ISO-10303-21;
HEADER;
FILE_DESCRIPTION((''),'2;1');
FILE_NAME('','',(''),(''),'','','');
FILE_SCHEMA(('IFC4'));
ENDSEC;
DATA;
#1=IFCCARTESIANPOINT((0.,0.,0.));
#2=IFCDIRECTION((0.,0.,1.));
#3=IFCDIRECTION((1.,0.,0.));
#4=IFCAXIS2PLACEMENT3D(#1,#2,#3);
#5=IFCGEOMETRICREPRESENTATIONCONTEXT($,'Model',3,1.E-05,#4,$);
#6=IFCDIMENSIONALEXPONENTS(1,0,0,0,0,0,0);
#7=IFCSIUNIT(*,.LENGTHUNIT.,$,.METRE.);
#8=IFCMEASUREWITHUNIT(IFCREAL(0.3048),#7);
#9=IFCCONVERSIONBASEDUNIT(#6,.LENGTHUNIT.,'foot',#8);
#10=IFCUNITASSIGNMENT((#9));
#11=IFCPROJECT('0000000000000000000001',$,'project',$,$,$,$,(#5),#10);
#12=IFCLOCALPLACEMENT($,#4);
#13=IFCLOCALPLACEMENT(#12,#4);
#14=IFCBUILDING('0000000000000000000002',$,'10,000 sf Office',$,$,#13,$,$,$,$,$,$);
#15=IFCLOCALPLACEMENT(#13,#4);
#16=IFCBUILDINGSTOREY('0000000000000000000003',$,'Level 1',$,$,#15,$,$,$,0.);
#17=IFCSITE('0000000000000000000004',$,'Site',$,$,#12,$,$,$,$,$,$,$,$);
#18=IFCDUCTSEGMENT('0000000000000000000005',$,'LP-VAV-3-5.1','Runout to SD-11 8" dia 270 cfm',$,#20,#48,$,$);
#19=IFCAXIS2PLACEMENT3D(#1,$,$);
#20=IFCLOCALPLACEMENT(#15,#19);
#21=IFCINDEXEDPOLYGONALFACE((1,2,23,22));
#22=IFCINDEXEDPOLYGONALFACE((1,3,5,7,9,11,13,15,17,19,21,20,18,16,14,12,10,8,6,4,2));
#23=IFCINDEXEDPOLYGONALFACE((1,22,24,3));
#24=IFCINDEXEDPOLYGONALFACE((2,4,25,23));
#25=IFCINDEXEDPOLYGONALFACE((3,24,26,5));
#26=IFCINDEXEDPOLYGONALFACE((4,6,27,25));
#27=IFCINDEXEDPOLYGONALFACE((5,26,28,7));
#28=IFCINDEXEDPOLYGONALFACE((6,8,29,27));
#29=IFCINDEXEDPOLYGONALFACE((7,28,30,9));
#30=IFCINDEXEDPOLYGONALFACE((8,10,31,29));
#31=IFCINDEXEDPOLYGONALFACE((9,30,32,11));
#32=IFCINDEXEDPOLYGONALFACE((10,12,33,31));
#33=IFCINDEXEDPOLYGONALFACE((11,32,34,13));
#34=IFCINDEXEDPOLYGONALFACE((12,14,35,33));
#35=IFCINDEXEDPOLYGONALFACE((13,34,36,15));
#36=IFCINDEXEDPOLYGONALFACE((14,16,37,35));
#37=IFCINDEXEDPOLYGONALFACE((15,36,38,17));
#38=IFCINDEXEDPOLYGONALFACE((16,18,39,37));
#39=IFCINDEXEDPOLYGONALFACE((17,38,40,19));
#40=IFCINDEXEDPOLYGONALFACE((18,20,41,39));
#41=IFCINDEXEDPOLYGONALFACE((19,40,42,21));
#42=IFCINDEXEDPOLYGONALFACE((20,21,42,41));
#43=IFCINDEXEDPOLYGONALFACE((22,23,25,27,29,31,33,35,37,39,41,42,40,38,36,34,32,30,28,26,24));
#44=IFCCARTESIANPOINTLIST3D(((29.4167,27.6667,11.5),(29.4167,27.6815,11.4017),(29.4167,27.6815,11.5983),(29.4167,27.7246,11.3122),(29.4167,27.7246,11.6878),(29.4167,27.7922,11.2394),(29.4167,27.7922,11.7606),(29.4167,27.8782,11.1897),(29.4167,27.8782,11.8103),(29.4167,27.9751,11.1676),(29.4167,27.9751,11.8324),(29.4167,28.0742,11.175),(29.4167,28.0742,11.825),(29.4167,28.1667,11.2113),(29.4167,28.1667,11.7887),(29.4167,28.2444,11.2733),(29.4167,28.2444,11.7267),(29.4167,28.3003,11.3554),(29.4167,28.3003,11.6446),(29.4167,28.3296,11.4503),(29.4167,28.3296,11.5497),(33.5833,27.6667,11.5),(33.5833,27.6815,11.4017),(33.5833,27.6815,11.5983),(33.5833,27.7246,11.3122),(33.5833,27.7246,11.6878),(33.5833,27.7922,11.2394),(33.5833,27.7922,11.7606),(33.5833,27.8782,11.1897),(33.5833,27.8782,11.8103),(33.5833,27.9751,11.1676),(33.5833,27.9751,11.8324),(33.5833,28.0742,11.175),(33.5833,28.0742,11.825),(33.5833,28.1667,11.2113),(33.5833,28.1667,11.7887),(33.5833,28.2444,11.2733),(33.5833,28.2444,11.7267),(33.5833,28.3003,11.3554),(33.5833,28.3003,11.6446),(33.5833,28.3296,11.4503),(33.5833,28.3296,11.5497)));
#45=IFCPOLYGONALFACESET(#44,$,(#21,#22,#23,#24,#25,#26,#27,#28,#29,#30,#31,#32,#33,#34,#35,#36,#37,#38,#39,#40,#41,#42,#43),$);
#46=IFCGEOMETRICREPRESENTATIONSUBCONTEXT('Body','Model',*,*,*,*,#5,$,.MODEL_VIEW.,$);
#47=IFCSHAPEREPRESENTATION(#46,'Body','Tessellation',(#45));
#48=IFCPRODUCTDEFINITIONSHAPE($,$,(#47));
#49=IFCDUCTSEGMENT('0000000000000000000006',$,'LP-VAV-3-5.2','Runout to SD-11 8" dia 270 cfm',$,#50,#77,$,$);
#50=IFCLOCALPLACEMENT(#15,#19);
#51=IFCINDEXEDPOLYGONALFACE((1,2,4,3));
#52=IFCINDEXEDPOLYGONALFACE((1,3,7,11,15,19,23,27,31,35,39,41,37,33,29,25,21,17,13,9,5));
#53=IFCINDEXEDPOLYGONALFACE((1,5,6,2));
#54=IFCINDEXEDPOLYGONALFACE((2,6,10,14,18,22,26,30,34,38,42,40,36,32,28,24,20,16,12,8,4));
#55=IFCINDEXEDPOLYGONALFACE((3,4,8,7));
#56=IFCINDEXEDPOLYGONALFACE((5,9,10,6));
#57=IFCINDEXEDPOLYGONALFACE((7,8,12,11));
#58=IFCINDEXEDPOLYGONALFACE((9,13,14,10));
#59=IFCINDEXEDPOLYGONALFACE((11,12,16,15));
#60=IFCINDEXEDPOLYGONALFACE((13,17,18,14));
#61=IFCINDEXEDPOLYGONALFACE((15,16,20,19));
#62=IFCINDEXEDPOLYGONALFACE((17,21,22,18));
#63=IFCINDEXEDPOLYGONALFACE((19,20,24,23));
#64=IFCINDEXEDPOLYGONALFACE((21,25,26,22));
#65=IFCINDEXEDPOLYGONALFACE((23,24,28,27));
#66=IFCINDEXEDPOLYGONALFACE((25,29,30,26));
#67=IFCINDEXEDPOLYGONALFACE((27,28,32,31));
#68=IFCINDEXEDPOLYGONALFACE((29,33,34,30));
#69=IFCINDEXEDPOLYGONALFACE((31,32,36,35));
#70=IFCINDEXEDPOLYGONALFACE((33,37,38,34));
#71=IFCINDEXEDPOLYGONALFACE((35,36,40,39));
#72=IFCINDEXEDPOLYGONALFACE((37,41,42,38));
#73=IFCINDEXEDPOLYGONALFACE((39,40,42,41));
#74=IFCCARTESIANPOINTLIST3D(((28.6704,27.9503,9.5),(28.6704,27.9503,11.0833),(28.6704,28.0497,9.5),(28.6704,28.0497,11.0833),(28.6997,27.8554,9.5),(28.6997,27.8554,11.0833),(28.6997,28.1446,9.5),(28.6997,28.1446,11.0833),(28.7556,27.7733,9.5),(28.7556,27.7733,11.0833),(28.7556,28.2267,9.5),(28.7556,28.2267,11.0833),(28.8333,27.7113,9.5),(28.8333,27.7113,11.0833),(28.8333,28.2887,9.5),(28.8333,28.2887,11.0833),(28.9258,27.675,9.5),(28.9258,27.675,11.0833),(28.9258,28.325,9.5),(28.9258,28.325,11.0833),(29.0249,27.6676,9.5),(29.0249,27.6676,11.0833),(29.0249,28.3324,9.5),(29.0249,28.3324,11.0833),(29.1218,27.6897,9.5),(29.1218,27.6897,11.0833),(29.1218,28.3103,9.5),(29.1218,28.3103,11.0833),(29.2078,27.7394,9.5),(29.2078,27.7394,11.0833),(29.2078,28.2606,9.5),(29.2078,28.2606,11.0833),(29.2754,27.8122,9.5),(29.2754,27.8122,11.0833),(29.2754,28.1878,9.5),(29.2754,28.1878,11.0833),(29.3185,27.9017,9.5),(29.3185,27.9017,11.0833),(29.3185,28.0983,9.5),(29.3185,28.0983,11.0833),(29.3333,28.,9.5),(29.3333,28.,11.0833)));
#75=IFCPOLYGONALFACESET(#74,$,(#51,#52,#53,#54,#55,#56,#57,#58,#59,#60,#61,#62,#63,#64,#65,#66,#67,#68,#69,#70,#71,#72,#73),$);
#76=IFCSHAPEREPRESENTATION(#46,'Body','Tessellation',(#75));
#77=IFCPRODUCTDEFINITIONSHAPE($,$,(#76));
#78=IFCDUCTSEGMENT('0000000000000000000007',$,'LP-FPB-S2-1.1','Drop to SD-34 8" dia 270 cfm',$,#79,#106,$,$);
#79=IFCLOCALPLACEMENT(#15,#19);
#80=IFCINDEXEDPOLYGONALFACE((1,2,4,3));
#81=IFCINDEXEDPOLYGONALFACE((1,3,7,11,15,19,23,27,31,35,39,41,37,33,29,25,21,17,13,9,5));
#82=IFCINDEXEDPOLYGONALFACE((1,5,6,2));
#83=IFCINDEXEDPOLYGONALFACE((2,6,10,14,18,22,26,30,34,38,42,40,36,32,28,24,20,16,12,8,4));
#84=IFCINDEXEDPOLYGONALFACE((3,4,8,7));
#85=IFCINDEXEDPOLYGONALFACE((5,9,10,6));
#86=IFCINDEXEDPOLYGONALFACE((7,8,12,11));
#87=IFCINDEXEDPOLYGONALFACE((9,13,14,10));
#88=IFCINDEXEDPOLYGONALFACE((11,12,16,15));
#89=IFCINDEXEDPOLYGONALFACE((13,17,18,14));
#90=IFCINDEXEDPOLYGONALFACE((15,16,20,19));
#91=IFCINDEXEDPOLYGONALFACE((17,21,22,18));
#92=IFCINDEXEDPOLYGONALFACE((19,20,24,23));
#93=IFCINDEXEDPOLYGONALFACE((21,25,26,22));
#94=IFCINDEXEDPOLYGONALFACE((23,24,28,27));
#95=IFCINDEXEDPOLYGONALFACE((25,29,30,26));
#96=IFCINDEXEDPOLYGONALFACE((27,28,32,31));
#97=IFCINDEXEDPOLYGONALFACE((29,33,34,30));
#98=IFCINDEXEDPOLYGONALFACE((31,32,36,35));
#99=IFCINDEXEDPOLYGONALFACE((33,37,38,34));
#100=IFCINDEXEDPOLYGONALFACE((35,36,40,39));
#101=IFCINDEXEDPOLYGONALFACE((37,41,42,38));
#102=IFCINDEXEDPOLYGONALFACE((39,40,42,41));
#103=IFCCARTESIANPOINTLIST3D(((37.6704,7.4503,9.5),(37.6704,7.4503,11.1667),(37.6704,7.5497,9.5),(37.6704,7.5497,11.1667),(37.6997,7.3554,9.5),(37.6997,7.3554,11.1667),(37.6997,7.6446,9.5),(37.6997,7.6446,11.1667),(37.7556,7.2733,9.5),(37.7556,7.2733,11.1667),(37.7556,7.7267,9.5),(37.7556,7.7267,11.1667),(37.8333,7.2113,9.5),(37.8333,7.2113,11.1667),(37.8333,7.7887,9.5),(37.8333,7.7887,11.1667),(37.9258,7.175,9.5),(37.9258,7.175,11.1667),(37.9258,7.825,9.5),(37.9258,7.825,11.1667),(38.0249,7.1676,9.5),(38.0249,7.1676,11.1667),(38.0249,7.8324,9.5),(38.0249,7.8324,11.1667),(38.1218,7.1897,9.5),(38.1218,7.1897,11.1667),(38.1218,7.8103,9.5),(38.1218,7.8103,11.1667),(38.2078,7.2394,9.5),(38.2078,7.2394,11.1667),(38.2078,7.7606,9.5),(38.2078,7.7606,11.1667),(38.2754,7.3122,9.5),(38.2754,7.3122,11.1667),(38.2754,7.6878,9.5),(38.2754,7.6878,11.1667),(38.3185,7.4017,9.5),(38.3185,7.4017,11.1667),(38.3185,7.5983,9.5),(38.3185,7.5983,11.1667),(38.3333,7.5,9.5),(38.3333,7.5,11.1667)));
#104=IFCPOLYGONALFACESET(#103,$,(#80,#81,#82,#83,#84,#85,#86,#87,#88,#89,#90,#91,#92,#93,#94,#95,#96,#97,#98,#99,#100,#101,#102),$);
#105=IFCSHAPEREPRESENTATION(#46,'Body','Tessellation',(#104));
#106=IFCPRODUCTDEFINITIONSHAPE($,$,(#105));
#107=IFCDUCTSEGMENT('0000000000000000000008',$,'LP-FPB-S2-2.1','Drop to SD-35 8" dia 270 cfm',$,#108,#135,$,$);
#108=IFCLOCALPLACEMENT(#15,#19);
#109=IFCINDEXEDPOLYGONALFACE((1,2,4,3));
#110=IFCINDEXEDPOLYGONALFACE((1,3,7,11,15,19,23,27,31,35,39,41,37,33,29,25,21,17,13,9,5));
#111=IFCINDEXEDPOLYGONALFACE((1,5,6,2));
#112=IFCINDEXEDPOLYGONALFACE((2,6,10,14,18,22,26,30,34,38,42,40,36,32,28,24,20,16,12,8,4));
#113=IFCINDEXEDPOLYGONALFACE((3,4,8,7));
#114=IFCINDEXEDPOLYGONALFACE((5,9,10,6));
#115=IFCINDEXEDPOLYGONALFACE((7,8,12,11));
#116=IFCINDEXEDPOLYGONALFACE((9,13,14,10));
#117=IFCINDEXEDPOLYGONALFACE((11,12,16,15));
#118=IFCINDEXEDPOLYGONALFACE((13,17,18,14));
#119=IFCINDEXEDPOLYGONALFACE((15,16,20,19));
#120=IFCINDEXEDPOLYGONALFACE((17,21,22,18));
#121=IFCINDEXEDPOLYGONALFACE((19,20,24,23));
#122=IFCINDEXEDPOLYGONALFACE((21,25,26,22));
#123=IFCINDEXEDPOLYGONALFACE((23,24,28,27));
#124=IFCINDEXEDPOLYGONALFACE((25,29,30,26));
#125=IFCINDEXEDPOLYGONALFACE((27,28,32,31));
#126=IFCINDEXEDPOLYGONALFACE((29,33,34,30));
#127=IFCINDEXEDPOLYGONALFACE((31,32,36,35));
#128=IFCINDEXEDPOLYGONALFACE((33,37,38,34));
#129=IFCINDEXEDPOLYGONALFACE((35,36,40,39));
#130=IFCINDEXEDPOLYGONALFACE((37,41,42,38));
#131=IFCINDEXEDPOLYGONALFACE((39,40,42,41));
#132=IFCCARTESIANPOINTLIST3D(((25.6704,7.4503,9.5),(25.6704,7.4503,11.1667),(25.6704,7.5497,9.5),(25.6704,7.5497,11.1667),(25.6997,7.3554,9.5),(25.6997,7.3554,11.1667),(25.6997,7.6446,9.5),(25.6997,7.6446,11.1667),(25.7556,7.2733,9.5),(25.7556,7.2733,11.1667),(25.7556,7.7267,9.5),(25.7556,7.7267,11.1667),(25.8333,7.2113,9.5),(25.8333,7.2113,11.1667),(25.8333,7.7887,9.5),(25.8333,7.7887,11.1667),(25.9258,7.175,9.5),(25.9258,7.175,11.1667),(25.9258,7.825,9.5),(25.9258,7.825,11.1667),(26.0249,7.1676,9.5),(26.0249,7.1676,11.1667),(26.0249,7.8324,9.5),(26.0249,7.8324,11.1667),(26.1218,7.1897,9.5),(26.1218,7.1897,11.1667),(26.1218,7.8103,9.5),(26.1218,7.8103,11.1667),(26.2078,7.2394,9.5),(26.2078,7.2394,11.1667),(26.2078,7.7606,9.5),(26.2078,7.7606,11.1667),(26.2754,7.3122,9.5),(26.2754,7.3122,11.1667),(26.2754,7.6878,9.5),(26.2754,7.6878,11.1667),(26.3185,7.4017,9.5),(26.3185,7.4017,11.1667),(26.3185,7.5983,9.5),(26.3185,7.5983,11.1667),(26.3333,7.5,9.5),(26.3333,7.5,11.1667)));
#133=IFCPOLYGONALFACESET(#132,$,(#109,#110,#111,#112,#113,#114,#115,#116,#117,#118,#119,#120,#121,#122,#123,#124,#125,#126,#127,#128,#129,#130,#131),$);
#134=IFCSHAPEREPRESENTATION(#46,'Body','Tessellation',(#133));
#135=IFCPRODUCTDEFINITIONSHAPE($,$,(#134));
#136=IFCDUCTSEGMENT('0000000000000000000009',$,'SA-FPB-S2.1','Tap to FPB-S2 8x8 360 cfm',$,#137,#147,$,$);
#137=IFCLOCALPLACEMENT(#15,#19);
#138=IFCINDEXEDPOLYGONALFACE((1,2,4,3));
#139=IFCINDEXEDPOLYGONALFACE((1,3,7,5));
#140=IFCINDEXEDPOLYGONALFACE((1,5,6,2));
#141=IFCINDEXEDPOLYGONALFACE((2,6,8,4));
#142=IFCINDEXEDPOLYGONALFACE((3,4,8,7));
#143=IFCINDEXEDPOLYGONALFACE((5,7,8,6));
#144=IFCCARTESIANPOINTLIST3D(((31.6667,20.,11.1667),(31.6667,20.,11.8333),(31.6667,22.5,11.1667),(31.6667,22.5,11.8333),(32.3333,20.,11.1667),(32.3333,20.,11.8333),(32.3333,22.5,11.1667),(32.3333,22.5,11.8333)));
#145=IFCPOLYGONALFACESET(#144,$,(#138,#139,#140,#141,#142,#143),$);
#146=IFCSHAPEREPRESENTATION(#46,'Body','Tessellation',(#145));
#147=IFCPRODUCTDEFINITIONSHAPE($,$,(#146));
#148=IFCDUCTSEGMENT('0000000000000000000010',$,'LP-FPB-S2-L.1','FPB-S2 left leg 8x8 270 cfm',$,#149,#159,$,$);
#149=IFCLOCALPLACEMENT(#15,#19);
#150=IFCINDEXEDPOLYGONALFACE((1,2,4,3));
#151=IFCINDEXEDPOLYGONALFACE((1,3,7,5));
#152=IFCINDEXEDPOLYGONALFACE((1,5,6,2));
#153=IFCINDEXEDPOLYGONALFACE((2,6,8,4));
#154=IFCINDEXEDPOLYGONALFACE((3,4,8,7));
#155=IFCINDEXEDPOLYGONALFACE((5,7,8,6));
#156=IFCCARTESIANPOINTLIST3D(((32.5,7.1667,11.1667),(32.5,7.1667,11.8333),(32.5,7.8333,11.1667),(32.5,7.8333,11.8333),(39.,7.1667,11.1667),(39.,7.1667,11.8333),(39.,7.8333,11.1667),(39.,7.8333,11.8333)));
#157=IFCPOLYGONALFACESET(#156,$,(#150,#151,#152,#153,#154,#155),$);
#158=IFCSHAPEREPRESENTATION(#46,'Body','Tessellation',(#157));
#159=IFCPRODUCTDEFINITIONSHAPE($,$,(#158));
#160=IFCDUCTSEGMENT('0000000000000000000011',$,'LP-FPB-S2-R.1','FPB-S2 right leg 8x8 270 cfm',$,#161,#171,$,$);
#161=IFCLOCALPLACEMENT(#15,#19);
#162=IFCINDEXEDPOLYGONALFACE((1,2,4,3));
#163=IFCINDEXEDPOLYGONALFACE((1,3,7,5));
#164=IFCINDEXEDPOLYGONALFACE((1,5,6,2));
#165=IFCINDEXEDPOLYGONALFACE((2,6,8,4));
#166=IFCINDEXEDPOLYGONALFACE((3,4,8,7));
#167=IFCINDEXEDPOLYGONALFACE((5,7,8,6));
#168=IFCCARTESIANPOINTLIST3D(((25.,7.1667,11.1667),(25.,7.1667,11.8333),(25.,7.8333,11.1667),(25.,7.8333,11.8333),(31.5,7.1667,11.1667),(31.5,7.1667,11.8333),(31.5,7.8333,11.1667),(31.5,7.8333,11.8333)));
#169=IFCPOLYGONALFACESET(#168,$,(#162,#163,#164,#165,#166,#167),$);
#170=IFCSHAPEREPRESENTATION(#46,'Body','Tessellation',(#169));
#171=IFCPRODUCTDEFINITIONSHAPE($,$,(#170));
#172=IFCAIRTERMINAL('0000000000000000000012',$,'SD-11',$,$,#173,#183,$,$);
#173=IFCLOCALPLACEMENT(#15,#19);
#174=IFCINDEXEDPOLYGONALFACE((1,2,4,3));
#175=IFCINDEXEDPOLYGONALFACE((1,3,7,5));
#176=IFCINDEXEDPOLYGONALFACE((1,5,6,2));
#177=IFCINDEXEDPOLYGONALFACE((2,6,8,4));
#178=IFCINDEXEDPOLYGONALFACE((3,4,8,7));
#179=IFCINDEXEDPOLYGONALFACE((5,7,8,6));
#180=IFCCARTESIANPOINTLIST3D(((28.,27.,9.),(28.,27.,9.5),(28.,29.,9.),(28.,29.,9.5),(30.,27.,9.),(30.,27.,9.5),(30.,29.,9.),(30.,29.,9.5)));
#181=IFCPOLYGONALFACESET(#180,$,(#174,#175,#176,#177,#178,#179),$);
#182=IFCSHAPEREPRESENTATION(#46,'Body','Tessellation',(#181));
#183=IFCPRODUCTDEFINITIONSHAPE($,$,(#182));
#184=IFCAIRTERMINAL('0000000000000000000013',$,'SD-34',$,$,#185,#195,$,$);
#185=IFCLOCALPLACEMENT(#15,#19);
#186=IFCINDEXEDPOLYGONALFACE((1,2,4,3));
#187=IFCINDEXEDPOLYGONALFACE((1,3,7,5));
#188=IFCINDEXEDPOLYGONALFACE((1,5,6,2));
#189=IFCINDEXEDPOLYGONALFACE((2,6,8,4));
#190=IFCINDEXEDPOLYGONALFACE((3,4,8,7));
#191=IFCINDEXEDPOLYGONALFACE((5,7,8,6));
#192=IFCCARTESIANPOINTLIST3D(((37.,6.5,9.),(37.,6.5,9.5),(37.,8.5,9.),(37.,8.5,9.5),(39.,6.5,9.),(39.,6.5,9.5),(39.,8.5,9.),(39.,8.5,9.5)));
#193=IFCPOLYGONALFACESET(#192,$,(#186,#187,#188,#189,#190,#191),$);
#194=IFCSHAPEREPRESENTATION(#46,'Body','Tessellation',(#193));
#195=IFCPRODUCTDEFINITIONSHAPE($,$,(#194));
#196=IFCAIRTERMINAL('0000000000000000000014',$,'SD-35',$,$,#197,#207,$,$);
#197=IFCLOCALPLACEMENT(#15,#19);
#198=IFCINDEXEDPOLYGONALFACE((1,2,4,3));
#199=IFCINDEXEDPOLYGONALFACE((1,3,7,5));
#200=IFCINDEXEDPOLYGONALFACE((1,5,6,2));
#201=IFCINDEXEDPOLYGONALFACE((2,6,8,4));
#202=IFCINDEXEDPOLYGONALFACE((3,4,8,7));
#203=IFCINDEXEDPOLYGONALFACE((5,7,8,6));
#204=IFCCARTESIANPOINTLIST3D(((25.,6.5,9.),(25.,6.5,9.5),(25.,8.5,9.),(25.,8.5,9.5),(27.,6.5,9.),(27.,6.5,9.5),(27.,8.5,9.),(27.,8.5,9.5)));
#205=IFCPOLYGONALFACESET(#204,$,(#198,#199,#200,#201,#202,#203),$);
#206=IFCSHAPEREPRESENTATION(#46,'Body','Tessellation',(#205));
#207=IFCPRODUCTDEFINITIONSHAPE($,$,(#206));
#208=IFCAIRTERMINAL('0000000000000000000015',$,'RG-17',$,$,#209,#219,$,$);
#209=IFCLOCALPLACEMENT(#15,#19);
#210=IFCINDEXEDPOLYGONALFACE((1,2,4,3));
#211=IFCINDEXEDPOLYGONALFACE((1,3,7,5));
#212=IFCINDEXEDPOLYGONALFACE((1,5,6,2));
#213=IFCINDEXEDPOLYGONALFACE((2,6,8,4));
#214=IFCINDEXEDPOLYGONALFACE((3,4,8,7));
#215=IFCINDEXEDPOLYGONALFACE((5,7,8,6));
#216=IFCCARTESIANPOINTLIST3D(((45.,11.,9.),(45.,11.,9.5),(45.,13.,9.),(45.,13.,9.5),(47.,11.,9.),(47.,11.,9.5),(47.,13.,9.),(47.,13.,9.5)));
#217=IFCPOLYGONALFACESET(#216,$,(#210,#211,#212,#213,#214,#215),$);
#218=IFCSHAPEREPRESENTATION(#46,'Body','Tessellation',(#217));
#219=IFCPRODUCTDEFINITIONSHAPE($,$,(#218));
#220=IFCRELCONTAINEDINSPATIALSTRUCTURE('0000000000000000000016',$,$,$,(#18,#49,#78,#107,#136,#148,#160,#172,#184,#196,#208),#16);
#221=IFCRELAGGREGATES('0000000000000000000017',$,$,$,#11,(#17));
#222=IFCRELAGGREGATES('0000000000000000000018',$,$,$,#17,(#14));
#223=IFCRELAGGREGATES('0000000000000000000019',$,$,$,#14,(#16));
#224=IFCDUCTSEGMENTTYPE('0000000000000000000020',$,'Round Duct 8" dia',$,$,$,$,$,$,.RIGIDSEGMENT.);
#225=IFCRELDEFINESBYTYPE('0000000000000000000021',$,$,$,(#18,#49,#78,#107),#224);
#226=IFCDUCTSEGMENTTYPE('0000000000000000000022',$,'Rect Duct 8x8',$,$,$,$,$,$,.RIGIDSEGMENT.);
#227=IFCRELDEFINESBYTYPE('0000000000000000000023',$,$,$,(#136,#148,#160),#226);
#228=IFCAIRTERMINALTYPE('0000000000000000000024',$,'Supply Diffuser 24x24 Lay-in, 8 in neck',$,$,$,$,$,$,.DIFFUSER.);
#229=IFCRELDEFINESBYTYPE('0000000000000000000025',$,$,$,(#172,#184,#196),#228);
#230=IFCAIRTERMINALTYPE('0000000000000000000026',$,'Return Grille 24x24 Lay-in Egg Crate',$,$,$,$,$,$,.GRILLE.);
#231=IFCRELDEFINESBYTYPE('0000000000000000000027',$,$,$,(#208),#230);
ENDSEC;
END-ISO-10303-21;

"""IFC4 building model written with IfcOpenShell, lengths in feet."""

from ifc_helpers import new_model, entity, si_unit, converted_unit, frame, origin_with_axes, place, context, subcontext, project, spatial, rectangle, circle, extrude, type_object, element, save


model = new_model("IFC4")

# Units and contexts
model_context = context("Model", 3, precision=1e-05, world=origin_with_axes())
body_context = subcontext(model_context, "Body", "Model", "MODEL_VIEW")
ifc_project = project(units=[converted_unit("LENGTHUNIT", "foot", entity("IfcReal", 0.3048), si_unit("LENGTHUNIT", "METRE"), dimensions=[1, 0, 0, 0, 0, 0, 0])], contexts=[model_context])

# Site, building, storey
site_placement = place(None, origin_with_axes())
site = spatial("IfcSite", under=ifc_project, at=site_placement, Name="Site")
building_placement = place(site_placement, origin_with_axes())
building = spatial("IfcBuilding", under=site, at=building_placement, Name="10,000 sf Office")
storey_placement = place(building_placement, origin_with_axes())
storey = spatial("IfcBuildingStorey", under=building, at=storey_placement, Name="Level 1", Elevation=0.0)

# Duct segments
duct_segment_type_1 = type_object("IfcDuctSegmentType", Name="Round Duct 8\" dia", PredefinedType="RIGIDSEGMENT")
duct_segment_1_placement = place(storey_placement, frame((33.5833, 28.0, 11.5), z_axis=(-1.0, 0.0, 0.0), x_axis=(0.0, -1.0, 0.0)))
element("IfcDuctSegment", 1, at=duct_segment_1_placement, inside=storey, type_object=duct_segment_type_1, Name="LP-VAV-3-5.1", Description="Runout to SD-11 8\" dia 270 cfm", context=body_context, shape_type="SweptSolid", body=[
    extrude(circle(Radius=0.3333), None, (0.0, 0.0, 1.0), 4.1667),
])
duct_segment_2_placement = place(storey_placement, frame((29.0, 28.0, 11.0833), z_axis=(0.0, 0.0, -1.0), x_axis=(1.0, 0.0, 0.0)))
element("IfcDuctSegment", 2, at=duct_segment_2_placement, inside=storey, type_object=duct_segment_type_1, Name="LP-VAV-3-5.2", Description="Runout to SD-11 8\" dia 270 cfm", context=body_context, shape_type="SweptSolid", body=[
    extrude(circle(Radius=0.3333), None, (0.0, 0.0, 1.0), 1.5833),
])
for number, where, z_axis, x_axis, name, description in (
    (3, (38.0, 7.5, 11.1667), (0.0, 0.0, -1.0), (1.0, 0.0, 0.0), "LP-FPB-S2-1.1", "Drop to SD-34 8\" dia 270 cfm"),
    (4, (26.0, 7.5, 11.1667), (0.0, 0.0, -1.0), (1.0, 0.0, 0.0), "LP-FPB-S2-2.1", "Drop to SD-35 8\" dia 270 cfm"),
):
    element("IfcDuctSegment", number, at=place(storey_placement, frame(where, z_axis=z_axis, x_axis=x_axis)), inside=storey, type_object=duct_segment_type_1, Name=name, Description=description, context=body_context, shape_type="SweptSolid", body=[
        extrude(circle(Radius=0.3333), None, (0.0, 0.0, 1.0), 1.6667),
    ])
duct_segment_type_2 = type_object("IfcDuctSegmentType", Name="Rect Duct 8x8", PredefinedType="RIGIDSEGMENT")
duct_segment_3_placement = place(storey_placement, frame((32.0, 22.5, 11.5), z_axis=(0.0, -1.0, 0.0), x_axis=(1.0, 0.0, 0.0)))
element("IfcDuctSegment", 5, at=duct_segment_3_placement, inside=storey, type_object=duct_segment_type_2, Name="SA-FPB-S2.1", Description="Tap to FPB-S2 8x8 360 cfm", context=body_context, shape_type="SweptSolid", body=[
    extrude(rectangle(XDim=0.6667, YDim=0.6667), None, (0.0, 0.0, 1.0), 2.5),
])
for number, where, z_axis, x_axis, name, description in (
    (6, (32.5, 7.5, 11.5), (1.0, 0.0, 0.0), (0.0, 1.0, 0.0), "LP-FPB-S2-L.1", "FPB-S2 left leg 8x8 270 cfm"),
    (7, (31.5, 7.5, 11.5), (-1.0, 0.0, 0.0), (0.0, -1.0, 0.0), "LP-FPB-S2-R.1", "FPB-S2 right leg 8x8 270 cfm"),
):
    element("IfcDuctSegment", number, at=place(storey_placement, frame(where, z_axis=z_axis, x_axis=x_axis)), inside=storey, type_object=duct_segment_type_2, Name=name, Description=description, context=body_context, shape_type="SweptSolid", body=[
        extrude(rectangle(XDim=0.6667, YDim=0.6667), None, (0.0, 0.0, 1.0), 6.5),
    ])

# Air terminals
air_terminal_type_1 = type_object("IfcAirTerminalType", Name="Supply Diffuser 24x24 Lay-in, 8 in neck", PredefinedType="DIFFUSER")
for number, where, z_axis, x_axis, name in (
    (8, (29.0, 28.0, 9.0), (0.0, 0.0, 1.0), (1.0, 0.0, 0.0), "SD-11"),
    (9, (38.0, 7.5, 9.0), (0.0, 0.0, 1.0), (1.0, 0.0, 0.0), "SD-34"),
    (10, (26.0, 7.5, 9.0), (0.0, 0.0, 1.0), (1.0, 0.0, 0.0), "SD-35"),
):
    element("IfcAirTerminal", number, at=place(storey_placement, frame(where, z_axis=z_axis, x_axis=x_axis)), inside=storey, type_object=air_terminal_type_1, Name=name, context=body_context, shape_type="SweptSolid", body=[
        extrude(rectangle(XDim=2.0, YDim=2.0), None, (0.0, 0.0, 1.0), 0.5),
    ])
air_terminal_type_2 = type_object("IfcAirTerminalType", Name="Return Grille 24x24 Lay-in Egg Crate", PredefinedType="GRILLE")
for number, where, z_axis, x_axis, name in (
    (11, (46.0, 12.0, 9.0), (0.0, 0.0, 1.0), (1.0, 0.0, 0.0), "RG-17"),
):
    element("IfcAirTerminal", number, at=place(storey_placement, frame(where, z_axis=z_axis, x_axis=x_axis)), inside=storey, type_object=air_terminal_type_2, Name=name, context=body_context, shape_type="SweptSolid", body=[
        extrude(rectangle(XDim=2.0, YDim=2.0), None, (0.0, 0.0, 1.0), 0.5),
    ])

save(model, "model.ifc")
